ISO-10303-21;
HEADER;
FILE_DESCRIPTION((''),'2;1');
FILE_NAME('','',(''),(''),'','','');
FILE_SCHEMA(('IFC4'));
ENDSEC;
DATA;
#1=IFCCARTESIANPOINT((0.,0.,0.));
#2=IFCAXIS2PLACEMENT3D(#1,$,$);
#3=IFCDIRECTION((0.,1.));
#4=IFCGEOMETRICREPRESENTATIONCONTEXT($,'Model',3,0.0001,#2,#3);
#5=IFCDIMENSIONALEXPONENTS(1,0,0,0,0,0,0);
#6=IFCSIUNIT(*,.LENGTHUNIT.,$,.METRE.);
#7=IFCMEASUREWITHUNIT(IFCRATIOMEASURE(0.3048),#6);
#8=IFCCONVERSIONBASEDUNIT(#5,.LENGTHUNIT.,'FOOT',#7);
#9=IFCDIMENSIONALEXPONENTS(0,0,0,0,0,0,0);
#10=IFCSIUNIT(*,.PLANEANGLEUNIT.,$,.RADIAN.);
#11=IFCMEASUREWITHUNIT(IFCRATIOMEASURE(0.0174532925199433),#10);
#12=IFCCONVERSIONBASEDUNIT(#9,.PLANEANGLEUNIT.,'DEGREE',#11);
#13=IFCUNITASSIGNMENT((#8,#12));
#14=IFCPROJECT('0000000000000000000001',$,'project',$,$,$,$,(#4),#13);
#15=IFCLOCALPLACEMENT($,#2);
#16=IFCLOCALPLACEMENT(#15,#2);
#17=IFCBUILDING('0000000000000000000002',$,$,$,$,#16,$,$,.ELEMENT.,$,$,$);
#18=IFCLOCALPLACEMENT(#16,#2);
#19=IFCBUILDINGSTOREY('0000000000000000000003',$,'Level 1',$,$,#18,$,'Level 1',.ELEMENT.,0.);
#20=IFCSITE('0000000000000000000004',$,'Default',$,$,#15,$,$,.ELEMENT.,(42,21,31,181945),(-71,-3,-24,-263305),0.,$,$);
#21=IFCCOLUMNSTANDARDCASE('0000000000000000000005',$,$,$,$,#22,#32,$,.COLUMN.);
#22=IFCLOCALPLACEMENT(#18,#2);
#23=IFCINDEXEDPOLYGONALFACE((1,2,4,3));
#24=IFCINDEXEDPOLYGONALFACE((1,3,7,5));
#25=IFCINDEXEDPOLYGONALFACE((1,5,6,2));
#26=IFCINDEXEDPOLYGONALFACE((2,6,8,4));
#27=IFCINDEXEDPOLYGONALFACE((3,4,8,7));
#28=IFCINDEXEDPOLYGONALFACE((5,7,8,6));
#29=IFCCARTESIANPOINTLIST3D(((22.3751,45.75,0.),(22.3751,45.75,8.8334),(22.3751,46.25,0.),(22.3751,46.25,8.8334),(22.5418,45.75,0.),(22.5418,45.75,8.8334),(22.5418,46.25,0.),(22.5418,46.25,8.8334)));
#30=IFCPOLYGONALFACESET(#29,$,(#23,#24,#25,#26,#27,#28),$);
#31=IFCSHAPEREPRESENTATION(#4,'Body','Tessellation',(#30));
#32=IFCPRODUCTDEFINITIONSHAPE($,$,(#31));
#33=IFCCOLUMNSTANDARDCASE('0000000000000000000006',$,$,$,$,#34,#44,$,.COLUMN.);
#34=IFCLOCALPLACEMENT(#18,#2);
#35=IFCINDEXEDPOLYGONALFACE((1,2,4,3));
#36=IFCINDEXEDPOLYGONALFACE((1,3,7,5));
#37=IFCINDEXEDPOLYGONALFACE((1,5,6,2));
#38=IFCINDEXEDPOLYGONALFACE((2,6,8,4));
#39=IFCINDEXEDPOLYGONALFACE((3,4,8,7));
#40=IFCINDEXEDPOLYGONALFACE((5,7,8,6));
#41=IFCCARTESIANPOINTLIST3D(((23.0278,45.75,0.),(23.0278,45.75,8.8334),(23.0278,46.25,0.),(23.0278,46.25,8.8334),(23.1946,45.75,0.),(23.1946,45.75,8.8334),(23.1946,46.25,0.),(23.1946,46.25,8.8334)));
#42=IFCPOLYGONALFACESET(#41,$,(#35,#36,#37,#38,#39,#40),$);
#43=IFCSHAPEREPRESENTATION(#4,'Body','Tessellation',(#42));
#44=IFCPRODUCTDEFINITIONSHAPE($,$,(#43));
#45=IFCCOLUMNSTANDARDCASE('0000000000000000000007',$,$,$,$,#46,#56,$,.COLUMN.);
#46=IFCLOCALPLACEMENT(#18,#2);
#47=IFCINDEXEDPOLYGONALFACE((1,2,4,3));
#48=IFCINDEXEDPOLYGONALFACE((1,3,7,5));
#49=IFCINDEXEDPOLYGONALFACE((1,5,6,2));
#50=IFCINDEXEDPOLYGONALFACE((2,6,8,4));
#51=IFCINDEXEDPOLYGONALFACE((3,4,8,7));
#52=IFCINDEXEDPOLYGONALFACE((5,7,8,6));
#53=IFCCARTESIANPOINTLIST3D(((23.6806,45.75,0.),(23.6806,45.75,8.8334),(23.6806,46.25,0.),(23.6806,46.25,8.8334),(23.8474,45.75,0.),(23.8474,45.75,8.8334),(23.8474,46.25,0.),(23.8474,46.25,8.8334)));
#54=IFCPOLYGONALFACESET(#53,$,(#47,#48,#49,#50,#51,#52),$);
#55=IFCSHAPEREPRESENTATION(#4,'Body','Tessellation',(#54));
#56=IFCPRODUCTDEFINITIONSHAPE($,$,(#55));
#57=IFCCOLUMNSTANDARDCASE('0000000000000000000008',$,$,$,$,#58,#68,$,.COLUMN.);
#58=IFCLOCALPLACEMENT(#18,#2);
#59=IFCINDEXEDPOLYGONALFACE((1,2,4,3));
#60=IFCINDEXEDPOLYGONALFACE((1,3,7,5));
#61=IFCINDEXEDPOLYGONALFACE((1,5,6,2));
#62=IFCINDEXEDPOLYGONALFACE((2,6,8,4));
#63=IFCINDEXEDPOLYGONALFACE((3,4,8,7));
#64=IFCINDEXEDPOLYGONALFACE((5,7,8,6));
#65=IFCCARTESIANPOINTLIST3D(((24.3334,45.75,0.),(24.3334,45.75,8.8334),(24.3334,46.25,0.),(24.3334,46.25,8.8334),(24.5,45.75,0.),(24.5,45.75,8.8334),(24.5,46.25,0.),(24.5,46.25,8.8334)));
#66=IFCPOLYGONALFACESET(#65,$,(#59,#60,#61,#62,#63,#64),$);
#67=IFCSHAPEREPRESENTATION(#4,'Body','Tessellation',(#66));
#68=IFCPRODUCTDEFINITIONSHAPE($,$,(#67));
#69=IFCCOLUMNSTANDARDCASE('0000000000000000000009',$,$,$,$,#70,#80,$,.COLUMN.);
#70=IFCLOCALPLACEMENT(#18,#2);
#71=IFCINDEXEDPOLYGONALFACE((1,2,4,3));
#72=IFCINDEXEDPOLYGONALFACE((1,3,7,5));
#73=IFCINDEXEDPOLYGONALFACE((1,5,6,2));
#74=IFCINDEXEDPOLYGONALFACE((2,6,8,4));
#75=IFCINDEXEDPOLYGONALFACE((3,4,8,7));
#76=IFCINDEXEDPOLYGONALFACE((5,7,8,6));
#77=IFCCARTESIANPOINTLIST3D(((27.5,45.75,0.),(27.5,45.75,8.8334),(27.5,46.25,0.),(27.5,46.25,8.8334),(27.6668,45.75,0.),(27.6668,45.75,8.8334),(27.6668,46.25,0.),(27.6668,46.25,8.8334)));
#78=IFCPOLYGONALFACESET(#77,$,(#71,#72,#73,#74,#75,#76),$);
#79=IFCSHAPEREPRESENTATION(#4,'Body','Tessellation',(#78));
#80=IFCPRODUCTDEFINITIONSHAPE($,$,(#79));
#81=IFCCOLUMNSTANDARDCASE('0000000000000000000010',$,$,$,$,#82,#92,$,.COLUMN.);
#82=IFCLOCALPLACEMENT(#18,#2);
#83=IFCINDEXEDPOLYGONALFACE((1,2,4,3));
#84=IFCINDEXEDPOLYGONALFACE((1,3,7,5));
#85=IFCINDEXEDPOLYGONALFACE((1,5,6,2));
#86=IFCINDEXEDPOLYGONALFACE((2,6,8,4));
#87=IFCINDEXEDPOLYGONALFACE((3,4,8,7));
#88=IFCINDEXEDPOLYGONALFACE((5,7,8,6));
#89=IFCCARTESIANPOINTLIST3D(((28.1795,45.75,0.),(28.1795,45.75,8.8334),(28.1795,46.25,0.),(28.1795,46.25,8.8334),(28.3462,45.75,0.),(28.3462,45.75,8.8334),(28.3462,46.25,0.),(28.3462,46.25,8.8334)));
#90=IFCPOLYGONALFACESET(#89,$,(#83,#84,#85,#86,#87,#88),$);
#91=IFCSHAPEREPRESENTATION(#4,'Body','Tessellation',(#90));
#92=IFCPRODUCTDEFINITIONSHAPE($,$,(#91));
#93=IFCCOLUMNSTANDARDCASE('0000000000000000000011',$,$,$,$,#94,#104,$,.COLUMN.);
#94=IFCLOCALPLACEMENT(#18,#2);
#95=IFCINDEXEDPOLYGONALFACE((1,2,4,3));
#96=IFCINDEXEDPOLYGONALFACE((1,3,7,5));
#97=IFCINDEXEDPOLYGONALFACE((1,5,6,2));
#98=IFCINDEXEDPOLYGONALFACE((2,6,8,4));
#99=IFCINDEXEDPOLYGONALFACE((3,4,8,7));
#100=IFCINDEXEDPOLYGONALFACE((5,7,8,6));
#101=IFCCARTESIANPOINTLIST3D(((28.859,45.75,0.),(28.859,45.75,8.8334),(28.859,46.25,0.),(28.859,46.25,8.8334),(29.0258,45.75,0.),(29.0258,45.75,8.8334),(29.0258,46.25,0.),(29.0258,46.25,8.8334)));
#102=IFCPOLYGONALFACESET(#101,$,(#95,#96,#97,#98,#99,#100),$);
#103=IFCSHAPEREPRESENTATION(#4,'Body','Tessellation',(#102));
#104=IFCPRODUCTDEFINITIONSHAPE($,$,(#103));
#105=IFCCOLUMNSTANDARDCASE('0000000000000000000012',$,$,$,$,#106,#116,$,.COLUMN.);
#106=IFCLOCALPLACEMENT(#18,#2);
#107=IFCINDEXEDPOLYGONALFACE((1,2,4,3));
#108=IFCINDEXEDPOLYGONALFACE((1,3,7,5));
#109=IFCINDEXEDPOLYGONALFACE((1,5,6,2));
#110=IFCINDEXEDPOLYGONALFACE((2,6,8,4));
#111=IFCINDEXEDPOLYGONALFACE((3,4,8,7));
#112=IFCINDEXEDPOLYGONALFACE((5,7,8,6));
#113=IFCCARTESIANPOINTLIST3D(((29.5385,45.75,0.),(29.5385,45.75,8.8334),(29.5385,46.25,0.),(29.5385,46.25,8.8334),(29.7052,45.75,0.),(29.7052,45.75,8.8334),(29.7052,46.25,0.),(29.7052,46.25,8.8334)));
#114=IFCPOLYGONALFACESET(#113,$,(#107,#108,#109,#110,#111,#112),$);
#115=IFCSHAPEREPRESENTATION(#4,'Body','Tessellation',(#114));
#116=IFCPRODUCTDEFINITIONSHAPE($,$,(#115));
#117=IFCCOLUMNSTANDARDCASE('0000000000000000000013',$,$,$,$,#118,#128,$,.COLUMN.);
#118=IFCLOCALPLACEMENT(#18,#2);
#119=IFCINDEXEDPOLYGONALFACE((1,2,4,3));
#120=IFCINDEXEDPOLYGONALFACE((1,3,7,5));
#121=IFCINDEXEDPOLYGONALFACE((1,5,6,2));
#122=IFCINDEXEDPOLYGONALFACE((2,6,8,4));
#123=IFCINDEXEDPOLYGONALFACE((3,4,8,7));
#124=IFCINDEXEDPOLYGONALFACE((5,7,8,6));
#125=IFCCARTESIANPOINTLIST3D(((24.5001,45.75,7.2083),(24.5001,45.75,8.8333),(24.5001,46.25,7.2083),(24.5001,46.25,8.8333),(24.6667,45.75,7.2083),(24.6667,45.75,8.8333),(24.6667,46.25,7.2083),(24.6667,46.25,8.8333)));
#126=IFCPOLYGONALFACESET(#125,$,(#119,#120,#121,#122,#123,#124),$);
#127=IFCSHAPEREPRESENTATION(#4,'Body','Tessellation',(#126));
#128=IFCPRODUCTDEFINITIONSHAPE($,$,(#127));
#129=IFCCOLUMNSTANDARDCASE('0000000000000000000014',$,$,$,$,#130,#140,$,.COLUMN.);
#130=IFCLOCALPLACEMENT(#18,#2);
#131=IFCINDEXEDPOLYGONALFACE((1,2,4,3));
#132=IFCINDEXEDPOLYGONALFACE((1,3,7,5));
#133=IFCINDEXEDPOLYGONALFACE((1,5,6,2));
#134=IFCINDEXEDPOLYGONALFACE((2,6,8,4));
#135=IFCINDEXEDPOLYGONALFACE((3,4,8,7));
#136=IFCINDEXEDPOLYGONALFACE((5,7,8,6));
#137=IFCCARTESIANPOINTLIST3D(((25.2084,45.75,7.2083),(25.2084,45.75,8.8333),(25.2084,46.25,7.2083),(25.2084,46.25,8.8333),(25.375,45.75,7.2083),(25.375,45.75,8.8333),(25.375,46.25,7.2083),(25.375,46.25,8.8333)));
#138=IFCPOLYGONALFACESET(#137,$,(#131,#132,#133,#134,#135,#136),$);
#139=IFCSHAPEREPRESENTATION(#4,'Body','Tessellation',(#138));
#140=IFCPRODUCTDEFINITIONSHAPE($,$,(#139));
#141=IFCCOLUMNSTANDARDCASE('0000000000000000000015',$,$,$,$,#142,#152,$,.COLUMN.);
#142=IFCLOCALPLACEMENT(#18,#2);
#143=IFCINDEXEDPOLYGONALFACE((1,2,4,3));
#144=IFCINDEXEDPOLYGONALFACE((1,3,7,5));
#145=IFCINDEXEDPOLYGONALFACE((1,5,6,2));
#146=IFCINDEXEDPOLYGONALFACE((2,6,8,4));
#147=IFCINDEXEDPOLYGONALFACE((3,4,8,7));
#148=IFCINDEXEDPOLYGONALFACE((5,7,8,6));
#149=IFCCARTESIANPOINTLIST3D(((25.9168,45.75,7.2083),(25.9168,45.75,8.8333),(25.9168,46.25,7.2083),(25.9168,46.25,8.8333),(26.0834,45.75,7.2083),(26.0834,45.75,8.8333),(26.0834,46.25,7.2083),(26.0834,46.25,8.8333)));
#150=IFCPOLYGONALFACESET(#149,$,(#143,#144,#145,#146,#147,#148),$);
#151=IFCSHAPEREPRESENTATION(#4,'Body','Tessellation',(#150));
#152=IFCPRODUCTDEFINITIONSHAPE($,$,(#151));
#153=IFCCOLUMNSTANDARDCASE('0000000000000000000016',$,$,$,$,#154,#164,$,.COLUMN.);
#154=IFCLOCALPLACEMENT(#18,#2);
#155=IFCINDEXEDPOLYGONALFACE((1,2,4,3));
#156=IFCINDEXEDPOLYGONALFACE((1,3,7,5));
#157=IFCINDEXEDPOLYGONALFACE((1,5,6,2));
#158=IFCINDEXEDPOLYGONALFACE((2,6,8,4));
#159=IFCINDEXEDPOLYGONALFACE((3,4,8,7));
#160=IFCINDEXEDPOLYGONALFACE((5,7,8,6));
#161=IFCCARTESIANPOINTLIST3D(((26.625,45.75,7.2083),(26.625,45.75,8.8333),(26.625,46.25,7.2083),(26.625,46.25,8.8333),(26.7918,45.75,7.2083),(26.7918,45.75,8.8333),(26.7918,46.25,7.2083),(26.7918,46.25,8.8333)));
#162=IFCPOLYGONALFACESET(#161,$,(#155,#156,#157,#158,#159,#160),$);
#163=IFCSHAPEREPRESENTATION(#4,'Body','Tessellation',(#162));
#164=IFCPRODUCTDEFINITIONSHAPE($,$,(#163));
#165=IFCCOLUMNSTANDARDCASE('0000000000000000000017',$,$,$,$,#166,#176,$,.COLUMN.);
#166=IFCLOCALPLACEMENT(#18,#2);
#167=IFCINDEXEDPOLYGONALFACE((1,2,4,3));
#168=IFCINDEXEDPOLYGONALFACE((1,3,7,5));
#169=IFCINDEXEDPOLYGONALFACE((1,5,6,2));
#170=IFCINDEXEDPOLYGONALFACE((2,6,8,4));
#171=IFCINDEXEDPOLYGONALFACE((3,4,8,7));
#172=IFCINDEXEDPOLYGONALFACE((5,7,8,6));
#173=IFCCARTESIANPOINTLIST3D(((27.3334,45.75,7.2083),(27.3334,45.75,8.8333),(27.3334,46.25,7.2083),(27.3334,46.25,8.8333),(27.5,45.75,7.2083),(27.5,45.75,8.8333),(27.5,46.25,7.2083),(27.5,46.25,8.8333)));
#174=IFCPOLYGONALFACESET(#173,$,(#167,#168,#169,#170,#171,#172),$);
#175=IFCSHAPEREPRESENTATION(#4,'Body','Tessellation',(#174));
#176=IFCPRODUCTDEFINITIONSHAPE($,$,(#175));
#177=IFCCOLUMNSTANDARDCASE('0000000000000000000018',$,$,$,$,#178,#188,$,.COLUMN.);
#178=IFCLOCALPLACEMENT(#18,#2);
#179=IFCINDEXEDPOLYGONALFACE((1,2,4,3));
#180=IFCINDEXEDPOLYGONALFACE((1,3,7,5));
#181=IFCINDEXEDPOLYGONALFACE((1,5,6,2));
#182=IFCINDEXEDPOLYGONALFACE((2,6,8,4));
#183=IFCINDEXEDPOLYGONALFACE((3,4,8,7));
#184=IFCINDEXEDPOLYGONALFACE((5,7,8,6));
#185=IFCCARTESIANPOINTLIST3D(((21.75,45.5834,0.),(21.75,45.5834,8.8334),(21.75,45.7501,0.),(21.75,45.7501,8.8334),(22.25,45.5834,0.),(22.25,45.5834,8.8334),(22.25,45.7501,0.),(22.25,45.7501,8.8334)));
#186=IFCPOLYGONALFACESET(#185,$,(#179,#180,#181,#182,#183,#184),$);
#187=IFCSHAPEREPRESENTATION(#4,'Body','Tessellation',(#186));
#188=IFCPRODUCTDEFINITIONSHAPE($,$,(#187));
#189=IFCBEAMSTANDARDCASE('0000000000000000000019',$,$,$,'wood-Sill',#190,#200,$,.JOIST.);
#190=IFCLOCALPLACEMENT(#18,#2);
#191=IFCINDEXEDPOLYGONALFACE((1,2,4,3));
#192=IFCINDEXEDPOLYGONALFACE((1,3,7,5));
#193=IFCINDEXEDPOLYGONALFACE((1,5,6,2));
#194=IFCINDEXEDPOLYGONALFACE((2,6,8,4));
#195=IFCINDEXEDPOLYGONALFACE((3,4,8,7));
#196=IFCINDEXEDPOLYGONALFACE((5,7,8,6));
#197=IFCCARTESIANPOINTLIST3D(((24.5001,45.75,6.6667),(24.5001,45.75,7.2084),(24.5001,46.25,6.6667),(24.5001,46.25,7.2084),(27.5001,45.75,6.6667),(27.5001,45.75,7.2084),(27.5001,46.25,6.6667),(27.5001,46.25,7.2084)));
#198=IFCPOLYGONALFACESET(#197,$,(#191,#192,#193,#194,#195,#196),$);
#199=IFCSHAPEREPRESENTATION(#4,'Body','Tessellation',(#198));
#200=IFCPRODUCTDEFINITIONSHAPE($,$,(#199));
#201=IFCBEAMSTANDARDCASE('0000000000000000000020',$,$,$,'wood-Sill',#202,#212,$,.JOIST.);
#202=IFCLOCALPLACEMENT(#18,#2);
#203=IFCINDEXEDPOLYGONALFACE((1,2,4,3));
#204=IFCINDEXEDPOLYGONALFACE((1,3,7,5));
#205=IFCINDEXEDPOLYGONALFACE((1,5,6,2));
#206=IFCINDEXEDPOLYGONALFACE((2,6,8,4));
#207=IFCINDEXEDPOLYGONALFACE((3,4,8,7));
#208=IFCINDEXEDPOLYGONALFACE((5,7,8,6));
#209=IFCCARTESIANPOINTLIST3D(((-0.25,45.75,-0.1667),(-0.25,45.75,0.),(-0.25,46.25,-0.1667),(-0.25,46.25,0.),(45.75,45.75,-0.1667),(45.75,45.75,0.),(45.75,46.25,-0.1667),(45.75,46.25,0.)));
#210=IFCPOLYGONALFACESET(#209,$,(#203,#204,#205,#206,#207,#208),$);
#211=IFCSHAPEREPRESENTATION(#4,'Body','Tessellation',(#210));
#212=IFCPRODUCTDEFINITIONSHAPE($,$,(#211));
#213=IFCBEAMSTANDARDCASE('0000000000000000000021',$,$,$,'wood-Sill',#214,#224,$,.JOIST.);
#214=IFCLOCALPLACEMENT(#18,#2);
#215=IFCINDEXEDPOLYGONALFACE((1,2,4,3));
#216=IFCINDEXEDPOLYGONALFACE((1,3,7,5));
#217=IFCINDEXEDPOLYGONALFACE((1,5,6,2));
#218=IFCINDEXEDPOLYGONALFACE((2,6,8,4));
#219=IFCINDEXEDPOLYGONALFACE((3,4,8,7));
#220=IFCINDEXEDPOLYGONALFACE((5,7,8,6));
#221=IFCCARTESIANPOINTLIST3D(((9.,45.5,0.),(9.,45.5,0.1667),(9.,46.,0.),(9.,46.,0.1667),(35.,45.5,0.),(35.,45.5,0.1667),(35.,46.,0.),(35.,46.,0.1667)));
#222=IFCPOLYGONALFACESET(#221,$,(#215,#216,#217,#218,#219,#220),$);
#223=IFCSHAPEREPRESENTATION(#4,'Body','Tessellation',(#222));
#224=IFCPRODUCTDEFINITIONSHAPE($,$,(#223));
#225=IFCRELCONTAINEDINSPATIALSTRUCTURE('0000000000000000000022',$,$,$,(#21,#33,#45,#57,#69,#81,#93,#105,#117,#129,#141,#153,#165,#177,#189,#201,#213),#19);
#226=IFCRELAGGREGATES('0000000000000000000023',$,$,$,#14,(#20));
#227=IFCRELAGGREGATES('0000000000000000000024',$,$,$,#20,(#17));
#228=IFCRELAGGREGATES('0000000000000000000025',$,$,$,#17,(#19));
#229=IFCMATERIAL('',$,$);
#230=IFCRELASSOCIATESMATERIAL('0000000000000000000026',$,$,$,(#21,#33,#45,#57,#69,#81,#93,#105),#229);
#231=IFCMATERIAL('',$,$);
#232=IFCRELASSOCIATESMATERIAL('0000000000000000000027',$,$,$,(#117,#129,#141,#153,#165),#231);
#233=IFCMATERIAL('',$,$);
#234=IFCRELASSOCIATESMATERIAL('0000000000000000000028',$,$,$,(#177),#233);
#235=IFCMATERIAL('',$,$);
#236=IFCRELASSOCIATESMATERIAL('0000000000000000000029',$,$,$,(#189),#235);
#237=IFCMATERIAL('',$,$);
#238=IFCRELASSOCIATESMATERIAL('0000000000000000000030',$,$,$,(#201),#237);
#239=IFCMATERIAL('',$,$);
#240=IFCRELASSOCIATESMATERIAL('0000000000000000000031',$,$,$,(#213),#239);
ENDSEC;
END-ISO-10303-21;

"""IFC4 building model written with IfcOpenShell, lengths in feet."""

from ifc_helpers import new_model, entity, si_unit, converted_unit, direction, frame, origin, place, context, project, spatial, rectangle, extrude, material, element, save


model = new_model("IFC4")

# Units and contexts
model_context = context("Model", 3, precision=0.0001, world=origin(), true_north=direction((0.0, 1.0)))
ifc_project = project(units=[converted_unit("LENGTHUNIT", "FOOT", entity("IfcRatioMeasure", 0.3048), si_unit("LENGTHUNIT", "METRE"), dimensions=[1, 0, 0, 0, 0, 0, 0]), converted_unit("PLANEANGLEUNIT", "DEGREE", entity("IfcRatioMeasure", 0.0174532925199433), si_unit("PLANEANGLEUNIT", "RADIAN"), dimensions=[0, 0, 0, 0, 0, 0, 0])], contexts=[model_context])

# Site, building, storey
site_placement = place(None, origin())
site = spatial("IfcSite", under=ifc_project, at=site_placement, Name="Default", CompositionType="ELEMENT", RefLatitude=(42, 21, 31, 181945), RefLongitude=(-71, -3, -24, -263305), RefElevation=0.0)
building_placement = place(site_placement, origin())
building = spatial("IfcBuilding", under=site, at=building_placement, CompositionType="ELEMENT")
storey_placement = place(building_placement, origin())
storey = spatial("IfcBuildingStorey", under=building, at=storey_placement, Name="Level 1", LongName="Level 1", CompositionType="ELEMENT", Elevation=0.0)

# Columns
ifc_material_1 = material(Name="")
placement_1 = place(storey_placement, frame((-0.25, 46.0, 0.0)))
for number, where, z_axis, x_axis in (
    (1, (22.7084, 0.0, 0.0), (0.0, 0.0, 1.0), (1.0, 0.0, 0.0)),
    (2, (23.3612, 0.0, 0.0), (0.0, 0.0, 1.0), (1.0, 0.0, 0.0)),
    (3, (24.014, 0.0, 0.0), (0.0, 0.0, 1.0), (1.0, 0.0, 0.0)),
    (4, (24.6667, 0.0, 0.0), (0.0, 0.0, 1.0), (1.0, 0.0, 0.0)),
    (5, (27.8334, 0.0, 0.0), (0.0, 0.0, 1.0), (1.0, 0.0, 0.0)),
    (6, (28.5129, 0.0, 0.0), (0.0, 0.0, 1.0), (1.0, 0.0, 0.0)),
    (7, (29.1924, 0.0, 0.0), (0.0, 0.0, 1.0), (1.0, 0.0, 0.0)),
    (8, (29.8719, 0.0, 0.0), (0.0, 0.0, 1.0), (1.0, 0.0, 0.0)),
):
    element("IfcColumnStandardCase", number, at=place(placement_1, frame(where, z_axis=z_axis, x_axis=x_axis)), inside=storey, material=ifc_material_1, PredefinedType="COLUMN", context=model_context, shape_type="SweptSolid", body=[
        extrude(rectangle(XDim=0.1667, YDim=0.5), origin(), (0.0, 0.0, 1.0), 8.8334),
    ])
ifc_material_2 = material(Name="")
for number, where, z_axis, x_axis in (
    (9, (24.8334, 0.0, 7.2083), (0.0, 0.0, 1.0), (1.0, 0.0, 0.0)),
    (10, (25.5417, 0.0, 7.2083), (0.0, 0.0, 1.0), (1.0, 0.0, 0.0)),
    (11, (26.2501, 0.0, 7.2083), (0.0, 0.0, 1.0), (1.0, 0.0, 0.0)),
    (12, (26.9584, 0.0, 7.2083), (0.0, 0.0, 1.0), (1.0, 0.0, 0.0)),
    (13, (27.6667, 0.0, 7.2083), (0.0, 0.0, 1.0), (1.0, 0.0, 0.0)),
):
    element("IfcColumnStandardCase", number, at=place(placement_1, frame(where, z_axis=z_axis, x_axis=x_axis)), inside=storey, material=ifc_material_2, PredefinedType="COLUMN", context=model_context, shape_type="SweptSolid", body=[
        extrude(rectangle(XDim=0.1667, YDim=0.5), origin(), (0.0, 0.0, 1.0), 1.625),
    ])
ifc_material_3 = material(Name="")
placement_2 = place(storey_placement, frame((22.0, 45.75, 0.0), z_axis=(0.0, 0.0, 1.0), x_axis=(0.0, -1.0, 0.0)))
for number, where, z_axis, x_axis in (
    (14, (0.0833, 0.0, 0.0), (0.0, 0.0, 1.0), (1.0, 0.0, 0.0)),
):
    element("IfcColumnStandardCase", number, at=place(placement_2, frame(where, z_axis=z_axis, x_axis=x_axis)), inside=storey, material=ifc_material_3, PredefinedType="COLUMN", context=model_context, shape_type="SweptSolid", body=[
        extrude(rectangle(XDim=0.1667, YDim=0.5), origin(), (0.0, 0.0, 1.0), 8.8334),
    ])

# Beams
ifc_material_4 = material(Name="")
beam_1_placement = place(placement_1, frame((26.2501, 0.0, 6.6667), z_axis=(0.0, 0.0, 1.0), x_axis=(-1.0, 0.0, 0.0)))
element("IfcBeamStandardCase", 15, at=beam_1_placement, inside=storey, material=ifc_material_4, ObjectType="wood-Sill", PredefinedType="JOIST", context=model_context, shape_type="SweptSolid", body=[
    extrude(rectangle(XDim=3.0, YDim=0.5), origin(), (0.0, 0.0, 1.0), 0.5417),
])
ifc_material_5 = material(Name="")
beam_2_placement = place(placement_1, frame((23.0, 0.0, -0.1667), z_axis=(0.0, 0.0, 1.0), x_axis=(1.0, 0.0, 0.0)))
element("IfcBeamStandardCase", 16, at=beam_2_placement, inside=storey, material=ifc_material_5, ObjectType="wood-Sill", PredefinedType="JOIST", context=model_context, shape_type="SweptSolid", body=[
    extrude(rectangle(XDim=46.0, YDim=0.5), origin(), (0.0, 0.0, 1.0), 0.1667),
])
ifc_material_6 = material(Name="")
beam_3_placement = place(placement_2, frame((0.0, 0.0, 0.0), z_axis=(0.0, 0.0, 1.0), x_axis=(0.0, -1.0, 0.0)))
element("IfcBeamStandardCase", 17, at=beam_3_placement, inside=storey, material=ifc_material_6, ObjectType="wood-Sill", PredefinedType="JOIST", context=model_context, shape_type="SweptSolid", body=[
    extrude(rectangle(XDim=26.0, YDim=0.5), origin(), (0.0, 0.0, 1.0), 0.1667),
])

save(model, "model.ifc")
